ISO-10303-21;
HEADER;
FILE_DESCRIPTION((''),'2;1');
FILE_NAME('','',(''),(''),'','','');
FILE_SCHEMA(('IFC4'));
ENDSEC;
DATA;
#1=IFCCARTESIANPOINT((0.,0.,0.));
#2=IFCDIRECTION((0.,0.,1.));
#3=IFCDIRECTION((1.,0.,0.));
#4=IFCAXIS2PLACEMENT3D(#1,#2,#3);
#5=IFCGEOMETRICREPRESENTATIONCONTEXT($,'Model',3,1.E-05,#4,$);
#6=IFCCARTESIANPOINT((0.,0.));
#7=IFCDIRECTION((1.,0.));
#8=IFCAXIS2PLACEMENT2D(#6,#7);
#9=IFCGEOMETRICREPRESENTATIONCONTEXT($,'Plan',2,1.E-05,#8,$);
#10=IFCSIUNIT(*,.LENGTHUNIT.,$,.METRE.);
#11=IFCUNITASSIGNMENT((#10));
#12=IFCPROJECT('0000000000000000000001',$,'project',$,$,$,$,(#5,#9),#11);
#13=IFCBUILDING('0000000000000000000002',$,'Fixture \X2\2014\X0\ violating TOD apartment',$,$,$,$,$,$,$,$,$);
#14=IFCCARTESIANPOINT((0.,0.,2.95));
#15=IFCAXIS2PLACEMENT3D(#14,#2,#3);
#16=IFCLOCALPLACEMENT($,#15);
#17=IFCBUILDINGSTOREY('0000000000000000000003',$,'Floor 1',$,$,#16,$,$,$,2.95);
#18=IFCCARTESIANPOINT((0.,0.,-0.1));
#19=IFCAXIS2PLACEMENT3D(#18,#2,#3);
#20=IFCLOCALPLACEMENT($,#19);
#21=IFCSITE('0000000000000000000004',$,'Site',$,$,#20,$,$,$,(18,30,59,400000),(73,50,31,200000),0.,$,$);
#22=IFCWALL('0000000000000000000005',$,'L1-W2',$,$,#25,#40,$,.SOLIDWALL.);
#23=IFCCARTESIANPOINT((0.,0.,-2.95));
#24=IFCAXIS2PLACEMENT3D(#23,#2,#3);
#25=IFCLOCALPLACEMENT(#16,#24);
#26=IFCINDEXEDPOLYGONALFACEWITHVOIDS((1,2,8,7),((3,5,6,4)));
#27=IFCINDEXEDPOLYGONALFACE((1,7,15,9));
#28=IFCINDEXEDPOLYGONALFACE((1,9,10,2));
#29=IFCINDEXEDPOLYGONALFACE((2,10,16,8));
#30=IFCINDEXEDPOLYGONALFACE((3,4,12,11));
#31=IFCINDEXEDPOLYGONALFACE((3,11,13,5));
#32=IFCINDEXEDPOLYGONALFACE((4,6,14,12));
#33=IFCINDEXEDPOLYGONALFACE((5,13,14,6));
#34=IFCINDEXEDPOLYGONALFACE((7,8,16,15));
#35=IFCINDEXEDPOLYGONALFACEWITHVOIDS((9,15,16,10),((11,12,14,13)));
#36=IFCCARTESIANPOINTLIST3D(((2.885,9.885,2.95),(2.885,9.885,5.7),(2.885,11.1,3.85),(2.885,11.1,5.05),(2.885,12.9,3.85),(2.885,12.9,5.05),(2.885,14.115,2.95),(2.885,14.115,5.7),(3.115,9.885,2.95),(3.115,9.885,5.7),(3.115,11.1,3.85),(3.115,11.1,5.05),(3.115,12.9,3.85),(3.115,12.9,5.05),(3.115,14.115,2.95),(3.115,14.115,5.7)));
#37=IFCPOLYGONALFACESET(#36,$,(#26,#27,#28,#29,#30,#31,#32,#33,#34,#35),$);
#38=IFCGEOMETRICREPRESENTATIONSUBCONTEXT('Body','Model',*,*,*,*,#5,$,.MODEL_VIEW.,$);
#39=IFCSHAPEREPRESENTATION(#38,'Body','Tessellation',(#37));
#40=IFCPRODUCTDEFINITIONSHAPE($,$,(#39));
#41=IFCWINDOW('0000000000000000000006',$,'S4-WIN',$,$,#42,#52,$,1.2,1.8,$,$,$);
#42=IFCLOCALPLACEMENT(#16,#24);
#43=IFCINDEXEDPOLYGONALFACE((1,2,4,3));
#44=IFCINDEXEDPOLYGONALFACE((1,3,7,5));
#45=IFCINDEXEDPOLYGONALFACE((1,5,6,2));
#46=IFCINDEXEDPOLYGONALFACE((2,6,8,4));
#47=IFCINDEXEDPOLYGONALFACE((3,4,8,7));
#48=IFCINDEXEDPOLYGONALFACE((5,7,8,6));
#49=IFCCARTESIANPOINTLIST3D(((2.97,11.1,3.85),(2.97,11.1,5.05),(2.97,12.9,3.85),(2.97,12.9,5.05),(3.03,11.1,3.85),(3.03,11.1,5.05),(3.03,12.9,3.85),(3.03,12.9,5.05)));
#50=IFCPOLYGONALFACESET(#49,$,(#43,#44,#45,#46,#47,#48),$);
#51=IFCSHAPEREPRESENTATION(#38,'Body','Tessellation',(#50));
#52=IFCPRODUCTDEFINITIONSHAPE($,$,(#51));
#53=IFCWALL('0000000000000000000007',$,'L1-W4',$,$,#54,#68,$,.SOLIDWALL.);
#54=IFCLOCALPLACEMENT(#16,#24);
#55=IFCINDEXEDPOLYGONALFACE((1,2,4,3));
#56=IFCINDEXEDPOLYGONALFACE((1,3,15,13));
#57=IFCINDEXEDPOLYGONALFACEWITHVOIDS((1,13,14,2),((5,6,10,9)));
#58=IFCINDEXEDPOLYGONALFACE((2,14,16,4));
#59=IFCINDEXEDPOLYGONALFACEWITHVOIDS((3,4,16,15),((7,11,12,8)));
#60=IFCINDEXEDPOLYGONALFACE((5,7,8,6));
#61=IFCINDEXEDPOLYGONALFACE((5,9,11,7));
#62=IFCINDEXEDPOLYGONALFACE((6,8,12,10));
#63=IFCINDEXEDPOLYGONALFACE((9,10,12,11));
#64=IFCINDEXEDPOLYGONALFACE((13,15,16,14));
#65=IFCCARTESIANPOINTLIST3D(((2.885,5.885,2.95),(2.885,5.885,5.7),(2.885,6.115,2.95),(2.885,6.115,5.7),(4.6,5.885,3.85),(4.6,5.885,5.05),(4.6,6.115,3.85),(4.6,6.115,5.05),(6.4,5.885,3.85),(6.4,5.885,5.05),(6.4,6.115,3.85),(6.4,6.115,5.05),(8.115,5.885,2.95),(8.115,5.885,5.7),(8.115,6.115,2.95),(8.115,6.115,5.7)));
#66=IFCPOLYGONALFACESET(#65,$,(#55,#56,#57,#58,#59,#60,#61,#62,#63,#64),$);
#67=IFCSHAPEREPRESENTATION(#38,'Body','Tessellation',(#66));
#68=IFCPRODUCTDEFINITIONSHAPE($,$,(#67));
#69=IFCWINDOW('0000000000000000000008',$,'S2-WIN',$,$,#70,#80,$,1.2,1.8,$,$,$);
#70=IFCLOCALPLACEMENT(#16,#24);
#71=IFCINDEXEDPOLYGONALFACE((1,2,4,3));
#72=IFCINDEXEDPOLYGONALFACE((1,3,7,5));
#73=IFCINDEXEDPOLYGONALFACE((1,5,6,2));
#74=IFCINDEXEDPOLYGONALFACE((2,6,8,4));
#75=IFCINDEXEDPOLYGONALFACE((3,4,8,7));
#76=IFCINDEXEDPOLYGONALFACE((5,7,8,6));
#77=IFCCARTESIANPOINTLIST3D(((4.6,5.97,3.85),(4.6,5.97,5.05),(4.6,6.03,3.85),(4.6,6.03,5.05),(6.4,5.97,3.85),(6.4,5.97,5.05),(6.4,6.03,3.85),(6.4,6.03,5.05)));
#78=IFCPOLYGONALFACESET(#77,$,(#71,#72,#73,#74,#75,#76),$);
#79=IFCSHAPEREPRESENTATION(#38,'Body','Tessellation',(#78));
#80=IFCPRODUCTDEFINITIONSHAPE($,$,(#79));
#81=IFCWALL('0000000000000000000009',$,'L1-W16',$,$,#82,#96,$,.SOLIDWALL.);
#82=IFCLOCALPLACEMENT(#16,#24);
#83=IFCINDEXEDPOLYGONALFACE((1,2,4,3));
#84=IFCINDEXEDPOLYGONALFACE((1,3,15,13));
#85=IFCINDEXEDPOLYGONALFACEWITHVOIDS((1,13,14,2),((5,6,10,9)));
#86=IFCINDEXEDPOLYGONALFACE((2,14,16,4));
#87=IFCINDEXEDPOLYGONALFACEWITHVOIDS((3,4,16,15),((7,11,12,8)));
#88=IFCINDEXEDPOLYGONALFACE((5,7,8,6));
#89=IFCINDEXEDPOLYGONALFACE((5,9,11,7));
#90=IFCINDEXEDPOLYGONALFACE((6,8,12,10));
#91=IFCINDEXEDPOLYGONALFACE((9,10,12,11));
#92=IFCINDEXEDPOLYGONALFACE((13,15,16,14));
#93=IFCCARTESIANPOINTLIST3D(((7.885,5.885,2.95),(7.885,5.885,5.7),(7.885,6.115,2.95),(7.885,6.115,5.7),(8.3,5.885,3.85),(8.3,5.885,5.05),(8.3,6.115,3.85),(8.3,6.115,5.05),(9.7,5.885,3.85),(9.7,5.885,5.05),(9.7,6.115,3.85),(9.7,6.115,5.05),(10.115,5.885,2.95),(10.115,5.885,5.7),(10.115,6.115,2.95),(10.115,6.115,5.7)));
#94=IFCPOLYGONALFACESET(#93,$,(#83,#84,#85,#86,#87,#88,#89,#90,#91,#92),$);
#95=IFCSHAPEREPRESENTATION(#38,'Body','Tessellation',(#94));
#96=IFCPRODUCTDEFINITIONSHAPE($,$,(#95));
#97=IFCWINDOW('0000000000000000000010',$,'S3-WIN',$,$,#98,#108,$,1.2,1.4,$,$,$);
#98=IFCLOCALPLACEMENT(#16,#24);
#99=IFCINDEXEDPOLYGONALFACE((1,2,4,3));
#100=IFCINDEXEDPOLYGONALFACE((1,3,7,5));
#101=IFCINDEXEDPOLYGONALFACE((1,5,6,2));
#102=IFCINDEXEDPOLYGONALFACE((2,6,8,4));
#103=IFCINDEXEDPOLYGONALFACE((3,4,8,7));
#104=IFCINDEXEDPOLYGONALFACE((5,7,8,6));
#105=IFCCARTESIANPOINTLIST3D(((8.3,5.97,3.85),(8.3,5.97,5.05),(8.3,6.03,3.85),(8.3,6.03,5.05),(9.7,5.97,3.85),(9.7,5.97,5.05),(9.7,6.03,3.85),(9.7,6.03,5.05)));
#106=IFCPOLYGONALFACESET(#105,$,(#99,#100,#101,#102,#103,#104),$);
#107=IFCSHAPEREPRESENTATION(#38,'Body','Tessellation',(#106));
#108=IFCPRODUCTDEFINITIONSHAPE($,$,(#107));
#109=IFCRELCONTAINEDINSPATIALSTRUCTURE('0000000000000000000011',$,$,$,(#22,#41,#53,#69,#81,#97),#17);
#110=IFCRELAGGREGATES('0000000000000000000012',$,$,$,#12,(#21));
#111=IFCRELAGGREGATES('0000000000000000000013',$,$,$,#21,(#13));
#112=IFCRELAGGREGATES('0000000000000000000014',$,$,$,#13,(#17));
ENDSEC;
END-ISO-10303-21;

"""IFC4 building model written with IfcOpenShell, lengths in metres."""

from ifc_helpers import new_model, si_unit, frame, origin_with_axes, origin_2d_with_axis, place, context, subcontext, project, spatial, line, indexed_curve, outline, extrude, element, fill, save


model = new_model("IFC4")

# Units and contexts
model_context = context("Model", 3, precision=1e-05, world=origin_with_axes())
plan_context = context("Plan", 2, precision=1e-05, world=origin_2d_with_axis())
body_context = subcontext(model_context, "Body", "Model", "MODEL_VIEW")
ifc_project = project(units=[si_unit("LENGTHUNIT", "METRE")], contexts=[model_context, plan_context])

# Site, building, storey
site_placement = place(None, frame((0.0, 0.0, -0.1), z_axis=(0.0, 0.0, 1.0), x_axis=(1.0, 0.0, 0.0)))
site = spatial("IfcSite", under=ifc_project, at=site_placement, Name="Site", RefLatitude=(18, 30, 59, 400000), RefLongitude=(73, 50, 31, 200000), RefElevation=0.0)
building = spatial("IfcBuilding", under=site, Name="Fixture — violating TOD apartment")
storey_placement = place(None, frame((0.0, 0.0, 2.95), z_axis=(0.0, 0.0, 1.0), x_axis=(1.0, 0.0, 0.0)))
storey = spatial("IfcBuildingStorey", under=building, at=storey_placement, Name="Floor 1", Elevation=2.95)

# Wall, opening, window
wall_1_placement = place(storey_placement, frame((0.0, 0.0, -2.95), z_axis=(0.0, 0.0, 1.0), x_axis=(1.0, 0.0, 0.0)))
wall_1 = element("IfcWall", 1, at=wall_1_placement, inside=storey, Name="L1-W2", PredefinedType="SOLIDWALL", context=body_context, shape_type="SweptSolid", body=[
    extrude(outline(indexed_curve([(3.115, 14.115), (3.115, 9.885), (2.885, 9.885), (2.885, 14.115)], segments=[line(1, 2, 3, 4, 1)])), frame((0.0, 0.0, 2.95), z_axis=(0.0, 0.0, 1.0), x_axis=(1.0, 0.0, 0.0)), (0.0, 0.0, 1.0), 2.75),
])
opening_1_placement = place(wall_1_placement, origin_with_axes())
opening_1 = element("IfcOpeningElement", 2, at=opening_1_placement, cuts=wall_1, context=body_context, shape_type="SweptSolid", body=[
    extrude(outline(indexed_curve([(3.165, 12.9), (3.165, 11.1), (2.835, 11.1), (2.835, 12.9)], segments=[line(1, 2, 3, 4, 1)])), frame((0.0, 0.0, 3.85), z_axis=(0.0, 0.0, 1.0), x_axis=(1.0, 0.0, 0.0)), (0.0, 0.0, 1.0), 1.2),
])
window_1_placement = place(storey_placement, frame((0.0, 0.0, -2.95), z_axis=(0.0, 0.0, 1.0), x_axis=(1.0, 0.0, 0.0)))
window_1 = element("IfcWindow", 3, at=window_1_placement, inside=storey, Name="S4-WIN", OverallHeight=1.2, OverallWidth=1.8, context=body_context, shape_type="SweptSolid", body=[
    extrude(outline(indexed_curve([(3.03, 12.9), (3.03, 11.1), (2.97, 11.1), (2.97, 12.9)], segments=[line(1, 2, 3, 4, 1)])), frame((0.0, 0.0, 3.85), z_axis=(0.0, 0.0, 1.0), x_axis=(1.0, 0.0, 0.0)), (0.0, 0.0, 1.0), 1.2),
])
fill(opening_1, window_1)

# Wall, opening, window
wall_2_placement = place(storey_placement, frame((0.0, 0.0, -2.95), z_axis=(0.0, 0.0, 1.0), x_axis=(1.0, 0.0, 0.0)))
wall_2 = element("IfcWall", 4, at=wall_2_placement, inside=storey, Name="L1-W4", PredefinedType="SOLIDWALL", context=body_context, shape_type="SweptSolid", body=[
    extrude(outline(indexed_curve([(2.885, 6.115), (8.115, 6.115), (8.115, 5.885), (2.885, 5.885)], segments=[line(1, 2, 3, 4, 1)])), frame((0.0, 0.0, 2.95), z_axis=(0.0, 0.0, 1.0), x_axis=(1.0, 0.0, 0.0)), (0.0, 0.0, 1.0), 2.75),
])
opening_2_placement = place(wall_2_placement, origin_with_axes())
opening_2 = element("IfcOpeningElement", 5, at=opening_2_placement, cuts=wall_2, context=body_context, shape_type="SweptSolid", body=[
    extrude(outline(indexed_curve([(4.6, 6.165), (6.4, 6.165), (6.4, 5.835), (4.6, 5.835)], segments=[line(1, 2, 3, 4, 1)])), frame((0.0, 0.0, 3.85), z_axis=(0.0, 0.0, 1.0), x_axis=(1.0, 0.0, 0.0)), (0.0, 0.0, 1.0), 1.2),
])
window_2_placement = place(storey_placement, frame((0.0, 0.0, -2.95), z_axis=(0.0, 0.0, 1.0), x_axis=(1.0, 0.0, 0.0)))
window_2 = element("IfcWindow", 6, at=window_2_placement, inside=storey, Name="S2-WIN", OverallHeight=1.2, OverallWidth=1.8, context=body_context, shape_type="SweptSolid", body=[
    extrude(outline(indexed_curve([(4.6, 6.03), (6.4, 6.03), (6.4, 5.97), (4.6, 5.97)], segments=[line(1, 2, 3, 4, 1)])), frame((0.0, 0.0, 3.85), z_axis=(0.0, 0.0, 1.0), x_axis=(1.0, 0.0, 0.0)), (0.0, 0.0, 1.0), 1.2),
])
fill(opening_2, window_2)

# Wall, opening, window
wall_3_placement = place(storey_placement, frame((0.0, 0.0, -2.95), z_axis=(0.0, 0.0, 1.0), x_axis=(1.0, 0.0, 0.0)))
wall_3 = element("IfcWall", 7, at=wall_3_placement, inside=storey, Name="L1-W16", PredefinedType="SOLIDWALL", context=body_context, shape_type="SweptSolid", body=[
    extrude(outline(indexed_curve([(7.885, 6.115), (10.115, 6.115), (10.115, 5.885), (7.885, 5.885)], segments=[line(1, 2, 3, 4, 1)])), frame((0.0, 0.0, 2.95), z_axis=(0.0, 0.0, 1.0), x_axis=(1.0, 0.0, 0.0)), (0.0, 0.0, 1.0), 2.75),
])
opening_3_placement = place(wall_3_placement, origin_with_axes())
opening_3 = element("IfcOpeningElement", 8, at=opening_3_placement, cuts=wall_3, context=body_context, shape_type="SweptSolid", body=[
    extrude(outline(indexed_curve([(8.3, 6.165), (9.7, 6.165), (9.7, 5.835), (8.3, 5.835)], segments=[line(1, 2, 3, 4, 1)])), frame((0.0, 0.0, 3.85), z_axis=(0.0, 0.0, 1.0), x_axis=(1.0, 0.0, 0.0)), (0.0, 0.0, 1.0), 1.2),
])
window_3_placement = place(storey_placement, frame((0.0, 0.0, -2.95), z_axis=(0.0, 0.0, 1.0), x_axis=(1.0, 0.0, 0.0)))
window_3 = element("IfcWindow", 9, at=window_3_placement, inside=storey, Name="S3-WIN", OverallHeight=1.2, OverallWidth=1.4, context=body_context, shape_type="SweptSolid", body=[
    extrude(outline(indexed_curve([(8.3, 6.03), (9.7, 6.03), (9.7, 5.97), (8.3, 5.97)], segments=[line(1, 2, 3, 4, 1)])), frame((0.0, 0.0, 3.85), z_axis=(0.0, 0.0, 1.0), x_axis=(1.0, 0.0, 0.0)), (0.0, 0.0, 1.0), 1.2),
])
fill(opening_3, window_3)

save(model, "model.ifc")
